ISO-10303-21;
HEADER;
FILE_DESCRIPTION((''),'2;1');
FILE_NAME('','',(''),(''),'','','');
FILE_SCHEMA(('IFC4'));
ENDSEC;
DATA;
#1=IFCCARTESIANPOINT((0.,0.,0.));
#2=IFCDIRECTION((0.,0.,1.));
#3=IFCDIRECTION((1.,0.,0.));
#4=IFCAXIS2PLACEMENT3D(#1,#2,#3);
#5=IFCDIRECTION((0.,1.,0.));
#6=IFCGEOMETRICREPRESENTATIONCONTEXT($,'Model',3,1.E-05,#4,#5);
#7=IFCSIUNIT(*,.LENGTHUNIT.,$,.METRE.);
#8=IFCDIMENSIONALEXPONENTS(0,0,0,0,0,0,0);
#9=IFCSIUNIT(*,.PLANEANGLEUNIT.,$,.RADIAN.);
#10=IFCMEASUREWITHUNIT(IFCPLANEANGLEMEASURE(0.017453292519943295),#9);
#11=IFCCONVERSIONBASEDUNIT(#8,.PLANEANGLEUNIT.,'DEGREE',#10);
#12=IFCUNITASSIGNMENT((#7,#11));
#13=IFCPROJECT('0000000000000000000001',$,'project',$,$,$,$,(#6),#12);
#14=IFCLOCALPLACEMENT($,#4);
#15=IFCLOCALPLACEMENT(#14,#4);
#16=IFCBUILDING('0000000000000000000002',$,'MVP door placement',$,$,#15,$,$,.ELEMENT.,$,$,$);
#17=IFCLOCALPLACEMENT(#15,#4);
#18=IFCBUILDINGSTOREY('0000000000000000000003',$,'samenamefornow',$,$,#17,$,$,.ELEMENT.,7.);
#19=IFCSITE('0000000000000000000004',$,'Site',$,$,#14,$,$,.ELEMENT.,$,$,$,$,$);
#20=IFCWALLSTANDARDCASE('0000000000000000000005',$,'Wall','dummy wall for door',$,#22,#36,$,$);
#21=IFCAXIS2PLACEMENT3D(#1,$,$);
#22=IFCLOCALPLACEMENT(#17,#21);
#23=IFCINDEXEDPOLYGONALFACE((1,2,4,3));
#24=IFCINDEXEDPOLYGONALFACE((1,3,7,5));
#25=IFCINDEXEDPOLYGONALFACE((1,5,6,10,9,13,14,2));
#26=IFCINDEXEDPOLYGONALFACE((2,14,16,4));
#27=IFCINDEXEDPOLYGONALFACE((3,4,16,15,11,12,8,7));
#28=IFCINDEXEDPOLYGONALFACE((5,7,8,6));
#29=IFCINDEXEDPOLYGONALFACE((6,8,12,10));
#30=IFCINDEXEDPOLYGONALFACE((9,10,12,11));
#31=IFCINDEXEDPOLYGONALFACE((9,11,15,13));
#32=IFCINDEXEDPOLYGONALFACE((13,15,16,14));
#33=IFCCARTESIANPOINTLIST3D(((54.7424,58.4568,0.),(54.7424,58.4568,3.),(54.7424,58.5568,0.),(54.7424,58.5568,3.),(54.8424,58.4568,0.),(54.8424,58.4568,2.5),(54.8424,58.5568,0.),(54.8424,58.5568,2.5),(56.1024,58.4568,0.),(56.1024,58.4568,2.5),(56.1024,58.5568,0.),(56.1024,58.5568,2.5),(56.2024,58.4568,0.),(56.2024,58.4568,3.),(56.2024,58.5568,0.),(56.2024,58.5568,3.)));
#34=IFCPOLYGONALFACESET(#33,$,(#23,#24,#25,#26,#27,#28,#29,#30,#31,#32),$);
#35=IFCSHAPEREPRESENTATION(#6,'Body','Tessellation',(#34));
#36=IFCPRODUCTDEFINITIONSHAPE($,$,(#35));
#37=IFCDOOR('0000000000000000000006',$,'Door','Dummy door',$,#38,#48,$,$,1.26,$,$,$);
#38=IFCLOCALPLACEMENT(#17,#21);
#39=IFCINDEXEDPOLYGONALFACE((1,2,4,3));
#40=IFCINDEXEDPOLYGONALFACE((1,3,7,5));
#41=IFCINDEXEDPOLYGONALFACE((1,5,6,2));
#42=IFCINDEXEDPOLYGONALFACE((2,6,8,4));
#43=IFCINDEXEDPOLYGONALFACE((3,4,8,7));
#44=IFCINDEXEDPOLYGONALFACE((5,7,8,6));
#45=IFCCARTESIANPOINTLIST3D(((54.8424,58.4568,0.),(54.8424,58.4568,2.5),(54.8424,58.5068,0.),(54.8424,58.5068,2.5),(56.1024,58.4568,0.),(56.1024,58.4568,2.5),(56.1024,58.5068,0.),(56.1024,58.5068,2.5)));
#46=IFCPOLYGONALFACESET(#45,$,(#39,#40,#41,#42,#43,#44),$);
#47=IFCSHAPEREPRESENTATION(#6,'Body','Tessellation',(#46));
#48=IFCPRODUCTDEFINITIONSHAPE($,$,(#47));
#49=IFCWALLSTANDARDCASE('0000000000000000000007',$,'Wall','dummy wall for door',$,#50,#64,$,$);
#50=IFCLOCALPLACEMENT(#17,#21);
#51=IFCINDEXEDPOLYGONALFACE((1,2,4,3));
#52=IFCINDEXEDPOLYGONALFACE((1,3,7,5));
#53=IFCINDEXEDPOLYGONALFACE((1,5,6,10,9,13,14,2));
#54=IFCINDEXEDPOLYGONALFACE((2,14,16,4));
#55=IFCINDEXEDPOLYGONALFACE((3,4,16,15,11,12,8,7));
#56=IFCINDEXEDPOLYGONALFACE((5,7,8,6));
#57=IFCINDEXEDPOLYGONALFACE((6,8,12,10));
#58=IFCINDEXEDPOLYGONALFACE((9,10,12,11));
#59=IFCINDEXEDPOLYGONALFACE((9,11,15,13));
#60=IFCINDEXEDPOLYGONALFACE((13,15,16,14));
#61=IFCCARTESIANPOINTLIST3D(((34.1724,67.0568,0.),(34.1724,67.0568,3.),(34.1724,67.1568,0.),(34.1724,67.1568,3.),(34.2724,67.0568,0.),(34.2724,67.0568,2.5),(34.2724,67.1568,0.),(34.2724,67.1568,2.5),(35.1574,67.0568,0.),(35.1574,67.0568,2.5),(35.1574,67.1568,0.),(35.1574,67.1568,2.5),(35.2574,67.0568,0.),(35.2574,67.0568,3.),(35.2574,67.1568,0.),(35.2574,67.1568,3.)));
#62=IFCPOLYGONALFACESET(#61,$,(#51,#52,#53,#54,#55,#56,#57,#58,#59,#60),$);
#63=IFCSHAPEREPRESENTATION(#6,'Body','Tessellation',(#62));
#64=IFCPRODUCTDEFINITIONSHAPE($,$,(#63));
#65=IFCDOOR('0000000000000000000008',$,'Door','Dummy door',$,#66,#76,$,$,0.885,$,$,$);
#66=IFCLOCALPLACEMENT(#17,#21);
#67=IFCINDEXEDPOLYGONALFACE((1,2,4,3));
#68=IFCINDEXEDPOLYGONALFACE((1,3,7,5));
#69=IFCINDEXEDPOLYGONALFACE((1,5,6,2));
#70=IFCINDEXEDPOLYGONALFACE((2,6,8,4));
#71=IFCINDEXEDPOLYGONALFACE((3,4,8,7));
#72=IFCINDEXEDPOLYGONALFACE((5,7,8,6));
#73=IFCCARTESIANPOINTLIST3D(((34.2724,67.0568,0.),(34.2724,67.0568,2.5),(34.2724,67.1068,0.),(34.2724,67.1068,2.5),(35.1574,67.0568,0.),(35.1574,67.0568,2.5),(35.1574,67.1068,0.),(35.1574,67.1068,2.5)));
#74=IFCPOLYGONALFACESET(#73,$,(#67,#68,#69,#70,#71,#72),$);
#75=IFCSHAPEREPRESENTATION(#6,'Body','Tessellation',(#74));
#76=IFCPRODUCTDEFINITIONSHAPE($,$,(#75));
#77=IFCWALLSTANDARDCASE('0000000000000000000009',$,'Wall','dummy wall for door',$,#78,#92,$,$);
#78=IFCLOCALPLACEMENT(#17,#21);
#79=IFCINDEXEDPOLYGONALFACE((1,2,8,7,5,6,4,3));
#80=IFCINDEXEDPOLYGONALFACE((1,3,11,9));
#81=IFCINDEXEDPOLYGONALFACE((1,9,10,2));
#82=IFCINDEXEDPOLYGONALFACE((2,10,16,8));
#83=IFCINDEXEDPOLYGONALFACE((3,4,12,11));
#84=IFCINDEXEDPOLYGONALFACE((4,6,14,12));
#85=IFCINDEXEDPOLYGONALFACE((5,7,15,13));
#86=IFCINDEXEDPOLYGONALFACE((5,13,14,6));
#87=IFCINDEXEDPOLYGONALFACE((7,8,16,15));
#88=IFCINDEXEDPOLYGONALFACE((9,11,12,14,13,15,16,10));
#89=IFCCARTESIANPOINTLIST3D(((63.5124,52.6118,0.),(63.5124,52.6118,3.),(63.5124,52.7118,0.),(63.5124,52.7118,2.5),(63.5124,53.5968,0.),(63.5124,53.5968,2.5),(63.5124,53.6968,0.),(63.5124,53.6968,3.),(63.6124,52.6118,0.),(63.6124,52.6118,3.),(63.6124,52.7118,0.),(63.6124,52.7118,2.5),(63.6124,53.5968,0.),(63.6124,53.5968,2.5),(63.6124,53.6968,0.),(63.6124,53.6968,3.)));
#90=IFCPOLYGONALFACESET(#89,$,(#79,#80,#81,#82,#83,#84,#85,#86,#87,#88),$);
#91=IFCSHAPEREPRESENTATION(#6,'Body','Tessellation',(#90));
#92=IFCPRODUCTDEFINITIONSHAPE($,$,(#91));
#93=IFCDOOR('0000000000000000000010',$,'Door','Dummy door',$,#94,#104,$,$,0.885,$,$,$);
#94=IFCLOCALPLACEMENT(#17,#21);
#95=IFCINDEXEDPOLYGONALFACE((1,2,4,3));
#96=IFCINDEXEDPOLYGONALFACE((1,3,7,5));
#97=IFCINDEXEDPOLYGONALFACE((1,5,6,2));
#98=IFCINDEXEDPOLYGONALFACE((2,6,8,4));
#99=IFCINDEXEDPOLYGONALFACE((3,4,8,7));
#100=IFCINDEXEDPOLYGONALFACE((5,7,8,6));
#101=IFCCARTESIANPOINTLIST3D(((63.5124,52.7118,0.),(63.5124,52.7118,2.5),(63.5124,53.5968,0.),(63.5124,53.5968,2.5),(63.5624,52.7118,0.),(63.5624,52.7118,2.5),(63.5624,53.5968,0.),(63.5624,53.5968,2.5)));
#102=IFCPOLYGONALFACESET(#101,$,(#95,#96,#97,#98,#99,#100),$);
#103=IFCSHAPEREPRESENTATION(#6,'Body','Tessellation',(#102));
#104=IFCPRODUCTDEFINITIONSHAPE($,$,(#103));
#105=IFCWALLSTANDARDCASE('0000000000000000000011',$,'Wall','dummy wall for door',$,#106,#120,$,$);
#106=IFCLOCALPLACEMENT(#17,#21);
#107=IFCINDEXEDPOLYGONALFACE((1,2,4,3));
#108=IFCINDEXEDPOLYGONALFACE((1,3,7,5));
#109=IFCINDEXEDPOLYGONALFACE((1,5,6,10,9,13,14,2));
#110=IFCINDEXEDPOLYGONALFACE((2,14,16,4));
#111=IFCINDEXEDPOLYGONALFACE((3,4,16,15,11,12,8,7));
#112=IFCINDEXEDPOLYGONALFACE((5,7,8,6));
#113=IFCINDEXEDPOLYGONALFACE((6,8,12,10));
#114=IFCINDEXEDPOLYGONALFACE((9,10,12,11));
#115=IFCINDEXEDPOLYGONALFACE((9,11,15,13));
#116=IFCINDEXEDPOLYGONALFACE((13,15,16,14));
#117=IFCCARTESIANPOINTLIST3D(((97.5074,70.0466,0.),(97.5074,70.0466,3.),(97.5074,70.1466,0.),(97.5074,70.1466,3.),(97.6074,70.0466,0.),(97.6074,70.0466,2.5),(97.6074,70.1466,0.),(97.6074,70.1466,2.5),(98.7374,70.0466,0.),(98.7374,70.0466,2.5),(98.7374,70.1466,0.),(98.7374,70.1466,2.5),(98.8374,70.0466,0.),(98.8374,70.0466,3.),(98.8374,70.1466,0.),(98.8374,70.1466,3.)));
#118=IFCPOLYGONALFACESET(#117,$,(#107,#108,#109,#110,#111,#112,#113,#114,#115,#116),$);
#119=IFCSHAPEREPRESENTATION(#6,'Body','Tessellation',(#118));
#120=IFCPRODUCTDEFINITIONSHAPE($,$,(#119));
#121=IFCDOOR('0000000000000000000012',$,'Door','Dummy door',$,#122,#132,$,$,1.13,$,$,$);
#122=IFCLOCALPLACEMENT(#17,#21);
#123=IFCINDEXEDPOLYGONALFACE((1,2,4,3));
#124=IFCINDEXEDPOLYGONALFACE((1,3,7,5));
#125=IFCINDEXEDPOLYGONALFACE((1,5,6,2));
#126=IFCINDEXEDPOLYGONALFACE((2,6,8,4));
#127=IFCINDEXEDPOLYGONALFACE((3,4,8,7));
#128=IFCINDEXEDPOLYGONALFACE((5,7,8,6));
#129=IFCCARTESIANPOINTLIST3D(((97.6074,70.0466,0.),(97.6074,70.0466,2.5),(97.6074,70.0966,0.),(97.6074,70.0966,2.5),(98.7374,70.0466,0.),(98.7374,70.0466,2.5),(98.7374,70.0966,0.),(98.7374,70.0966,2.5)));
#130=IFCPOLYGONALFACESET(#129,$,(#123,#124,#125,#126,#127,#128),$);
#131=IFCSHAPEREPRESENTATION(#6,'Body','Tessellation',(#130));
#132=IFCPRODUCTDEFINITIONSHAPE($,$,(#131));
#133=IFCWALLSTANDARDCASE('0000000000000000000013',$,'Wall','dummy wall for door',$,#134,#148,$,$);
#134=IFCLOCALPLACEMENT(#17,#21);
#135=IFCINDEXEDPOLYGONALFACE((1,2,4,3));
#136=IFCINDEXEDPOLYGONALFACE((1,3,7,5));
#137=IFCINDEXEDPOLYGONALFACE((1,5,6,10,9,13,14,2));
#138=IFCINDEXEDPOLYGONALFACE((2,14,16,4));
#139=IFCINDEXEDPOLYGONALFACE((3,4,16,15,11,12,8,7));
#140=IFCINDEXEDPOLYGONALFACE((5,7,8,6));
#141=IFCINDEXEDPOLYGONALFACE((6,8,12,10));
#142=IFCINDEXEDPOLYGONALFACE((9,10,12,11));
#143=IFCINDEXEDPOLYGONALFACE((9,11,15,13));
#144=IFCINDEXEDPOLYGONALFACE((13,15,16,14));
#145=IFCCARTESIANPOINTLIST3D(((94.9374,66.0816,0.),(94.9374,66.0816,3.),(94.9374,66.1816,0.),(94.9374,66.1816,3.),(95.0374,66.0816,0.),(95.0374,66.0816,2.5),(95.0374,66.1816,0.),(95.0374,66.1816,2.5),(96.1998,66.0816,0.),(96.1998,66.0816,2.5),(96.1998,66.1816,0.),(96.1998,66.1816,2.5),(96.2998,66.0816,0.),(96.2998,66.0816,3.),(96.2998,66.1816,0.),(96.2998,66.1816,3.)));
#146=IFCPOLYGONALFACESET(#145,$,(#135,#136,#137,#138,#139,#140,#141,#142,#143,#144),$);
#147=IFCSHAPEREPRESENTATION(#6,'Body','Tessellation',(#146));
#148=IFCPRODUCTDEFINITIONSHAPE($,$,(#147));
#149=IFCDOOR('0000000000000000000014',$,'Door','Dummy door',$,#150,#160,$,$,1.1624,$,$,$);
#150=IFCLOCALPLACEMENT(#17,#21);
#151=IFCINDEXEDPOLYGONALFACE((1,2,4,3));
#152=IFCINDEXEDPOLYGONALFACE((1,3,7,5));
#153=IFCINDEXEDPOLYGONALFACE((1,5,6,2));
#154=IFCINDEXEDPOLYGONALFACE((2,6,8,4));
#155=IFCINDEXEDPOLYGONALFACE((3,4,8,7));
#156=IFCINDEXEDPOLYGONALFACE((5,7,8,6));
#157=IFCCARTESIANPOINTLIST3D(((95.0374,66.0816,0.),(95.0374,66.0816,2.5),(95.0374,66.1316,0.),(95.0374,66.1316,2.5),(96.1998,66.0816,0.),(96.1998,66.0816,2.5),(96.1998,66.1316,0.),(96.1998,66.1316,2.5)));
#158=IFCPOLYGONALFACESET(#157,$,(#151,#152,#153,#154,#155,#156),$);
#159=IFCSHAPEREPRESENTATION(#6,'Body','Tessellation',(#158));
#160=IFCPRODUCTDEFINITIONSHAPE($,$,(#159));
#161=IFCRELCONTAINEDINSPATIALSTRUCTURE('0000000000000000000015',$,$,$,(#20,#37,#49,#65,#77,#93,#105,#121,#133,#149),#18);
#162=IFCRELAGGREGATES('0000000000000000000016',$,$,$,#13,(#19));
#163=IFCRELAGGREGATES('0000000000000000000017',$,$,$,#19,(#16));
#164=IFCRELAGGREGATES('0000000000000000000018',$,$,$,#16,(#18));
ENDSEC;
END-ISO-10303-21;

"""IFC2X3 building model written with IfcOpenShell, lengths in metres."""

from ifc_helpers import new_model, entity, si_unit, converted_unit, direction, origin_with_axes, place, context, project, spatial, polyline, outline, extrude, element, fill, save


model = new_model("IFC2X3")

# Units and contexts
model_context = context("Model", 3, precision=1e-05, world=origin_with_axes(), true_north=direction((0.0, 1.0, 0.0)))
ifc_project = project(units=[si_unit("LENGTHUNIT", "METRE"), converted_unit("PLANEANGLEUNIT", "DEGREE", entity("IfcPlaneAngleMeasure", 0.017453292519943295), si_unit("PLANEANGLEUNIT", "RADIAN"), dimensions=[0, 0, 0, 0, 0, 0, 0])], contexts=[model_context])

# Site, building, storey
site_placement = place(None, origin_with_axes())
site = spatial("IfcSite", under=ifc_project, at=site_placement, Name="Site", CompositionType="ELEMENT")
building_placement = place(site_placement, origin_with_axes())
building = spatial("IfcBuilding", under=site, at=building_placement, Name="MVP door placement", CompositionType="ELEMENT")
storey_placement = place(building_placement, origin_with_axes())
storey = spatial("IfcBuildingStorey", under=building, at=storey_placement, Name="samenamefornow", CompositionType="ELEMENT", Elevation=7.0)

# Walls, openings, doors
wall_1_placement = place(storey_placement, origin_with_axes())
wall_1 = element("IfcWallStandardCase", 1, at=wall_1_placement, inside=storey, Name="Wall", Description="dummy wall for door", context=model_context, shape_type="SweptSolid", body=[
    extrude(outline(polyline([(56.2024, 58.4568, 0.0), (54.7424, 58.4568, 0.0), (54.7424, 58.5568, 0.0), (56.2024, 58.5568, 0.0), (56.2024, 58.4568, 0.0)])), origin_with_axes(), (0.0, 0.0, 1.0), 3.0),
])
opening_1_placement = place(wall_1_placement, origin_with_axes())
opening_1 = element("IfcOpeningElement", 2, at=opening_1_placement, cuts=wall_1, context=model_context, shape_type="SweptSolid", body=[
    extrude(outline(polyline([(56.1024, 58.4568, 0.0), (54.8424, 58.4568, 0.0), (54.8424, 58.5568, 0.0), (56.1024, 58.5568, 0.0), (56.1024, 58.4568, 0.0)])), origin_with_axes(), (0.0, 0.0, 1.0), 2.5),
])
door_1_placement = place(opening_1_placement, origin_with_axes())
door_1 = element("IfcDoor", 3, at=door_1_placement, inside=storey, Name="Door", Description="Dummy door", OverallWidth=1.26, context=model_context, shape_type="SweptSolid", body=[
    extrude(outline(polyline([(56.1024, 58.4568, 0.0), (54.8424, 58.4568, 0.0), (54.8424, 58.5068, 0.0), (56.1024, 58.5068, 0.0), (56.1024, 58.4568, 0.0)])), origin_with_axes(), (0.0, 0.0, 1.0), 2.5),
])
fill(opening_1, door_1)
wall_2_placement = place(storey_placement, origin_with_axes())
wall_2 = element("IfcWallStandardCase", 4, at=wall_2_placement, inside=storey, Name="Wall", Description="dummy wall for door", context=model_context, shape_type="SweptSolid", body=[
    extrude(outline(polyline([(35.2574, 67.0568, 0.0), (34.1724, 67.0568, 0.0), (34.1724, 67.1568, 0.0), (35.2574, 67.1568, 0.0), (35.2574, 67.0568, 0.0)])), origin_with_axes(), (0.0, 0.0, 1.0), 3.0),
])
opening_2_placement = place(wall_2_placement, origin_with_axes())
opening_2 = element("IfcOpeningElement", 5, at=opening_2_placement, cuts=wall_2, context=model_context, shape_type="SweptSolid", body=[
    extrude(outline(polyline([(35.1574, 67.0568, 0.0), (34.2724, 67.0568, 0.0), (34.2724, 67.1568, 0.0), (35.1574, 67.1568, 0.0), (35.1574, 67.0568, 0.0)])), origin_with_axes(), (0.0, 0.0, 1.0), 2.5),
])
door_2_placement = place(opening_2_placement, origin_with_axes())
door_2 = element("IfcDoor", 6, at=door_2_placement, inside=storey, Name="Door", Description="Dummy door", OverallWidth=0.885, context=model_context, shape_type="SweptSolid", body=[
    extrude(outline(polyline([(35.1574, 67.0568, 0.0), (34.2724, 67.0568, 0.0), (34.2724, 67.1068, 0.0), (35.1574, 67.1068, 0.0), (35.1574, 67.0568, 0.0)])), origin_with_axes(), (0.0, 0.0, 1.0), 2.5),
])
fill(opening_2, door_2)
wall_3_placement = place(storey_placement, origin_with_axes())
wall_3 = element("IfcWallStandardCase", 7, at=wall_3_placement, inside=storey, Name="Wall", Description="dummy wall for door", context=model_context, shape_type="SweptSolid", body=[
    extrude(outline(polyline([(63.5124, 52.6118, 0.0), (63.5124, 53.6968, 0.0), (63.6124, 53.6968, 0.0), (63.6124, 52.6118, 0.0), (63.5124, 52.6118, 0.0)])), origin_with_axes(), (0.0, 0.0, 1.0), 3.0),
])
opening_3_placement = place(wall_3_placement, origin_with_axes())
opening_3 = element("IfcOpeningElement", 8, at=opening_3_placement, cuts=wall_3, context=model_context, shape_type="SweptSolid", body=[
    extrude(outline(polyline([(63.5124, 52.7118, 0.0), (63.5124, 53.5968, 0.0), (63.6124, 53.5968, 0.0), (63.6124, 52.7118, 0.0), (63.5124, 52.7118, 0.0)])), origin_with_axes(), (0.0, 0.0, 1.0), 2.5),
])
door_3_placement = place(opening_3_placement, origin_with_axes())
door_3 = element("IfcDoor", 9, at=door_3_placement, inside=storey, Name="Door", Description="Dummy door", OverallWidth=0.885, context=model_context, shape_type="SweptSolid", body=[
    extrude(outline(polyline([(63.5124, 52.7118, 0.0), (63.5124, 53.5968, 0.0), (63.5624, 53.5968, 0.0), (63.5624, 52.7118, 0.0), (63.5124, 52.7118, 0.0)])), origin_with_axes(), (0.0, 0.0, 1.0), 2.5),
])
fill(opening_3, door_3)
wall_4_placement = place(storey_placement, origin_with_axes())
wall_4 = element("IfcWallStandardCase", 10, at=wall_4_placement, inside=storey, Name="Wall", Description="dummy wall for door", context=model_context, shape_type="SweptSolid", body=[
    extrude(outline(polyline([(98.8374, 70.0466, 0.0), (97.5074, 70.0466, 0.0), (97.5074, 70.1466, 0.0), (98.8374, 70.1466, 0.0), (98.8374, 70.0466, 0.0)])), origin_with_axes(), (0.0, 0.0, 1.0), 3.0),
])
opening_4_placement = place(wall_4_placement, origin_with_axes())
opening_4 = element("IfcOpeningElement", 11, at=opening_4_placement, cuts=wall_4, context=model_context, shape_type="SweptSolid", body=[
    extrude(outline(polyline([(98.7374, 70.0466, 0.0), (97.6074, 70.0466, 0.0), (97.6074, 70.1466, 0.0), (98.7374, 70.1466, 0.0), (98.7374, 70.0466, 0.0)])), origin_with_axes(), (0.0, 0.0, 1.0), 2.5),
])
door_4_placement = place(opening_4_placement, origin_with_axes())
door_4 = element("IfcDoor", 12, at=door_4_placement, inside=storey, Name="Door", Description="Dummy door", OverallWidth=1.13, context=model_context, shape_type="SweptSolid", body=[
    extrude(outline(polyline([(98.7374, 70.0466, 0.0), (97.6074, 70.0466, 0.0), (97.6074, 70.0966, 0.0), (98.7374, 70.0966, 0.0), (98.7374, 70.0466, 0.0)])), origin_with_axes(), (0.0, 0.0, 1.0), 2.5),
])
fill(opening_4, door_4)
wall_5_placement = place(storey_placement, origin_with_axes())
wall_5 = element("IfcWallStandardCase", 13, at=wall_5_placement, inside=storey, Name="Wall", Description="dummy wall for door", context=model_context, shape_type="SweptSolid", body=[
    extrude(outline(polyline([(94.9374, 66.0816, 0.0), (96.2998, 66.0816, 0.0), (96.2998, 66.1816, 0.0), (94.9374, 66.1816, 0.0), (94.9374, 66.0816, 0.0)])), origin_with_axes(), (0.0, 0.0, 1.0), 3.0),
])
opening_5_placement = place(wall_5_placement, origin_with_axes())
opening_5 = element("IfcOpeningElement", 14, at=opening_5_placement, cuts=wall_5, context=model_context, shape_type="SweptSolid", body=[
    extrude(outline(polyline([(95.0374, 66.0816, 0.0), (96.1998, 66.0816, 0.0), (96.1998, 66.1816, 0.0), (95.0374, 66.1816, 0.0), (95.0374, 66.0816, 0.0)])), origin_with_axes(), (0.0, 0.0, 1.0), 2.5),
])
door_5_placement = place(opening_5_placement, origin_with_axes())
door_5 = element("IfcDoor", 15, at=door_5_placement, inside=storey, Name="Door", Description="Dummy door", OverallWidth=1.1624, context=model_context, shape_type="SweptSolid", body=[
    extrude(outline(polyline([(95.0374, 66.0816, 0.0), (96.1998, 66.0816, 0.0), (96.1998, 66.1316, 0.0), (95.0374, 66.1316, 0.0), (95.0374, 66.0816, 0.0)])), origin_with_axes(), (0.0, 0.0, 1.0), 2.5),
])
fill(opening_5, door_5)

save(model, "model.ifc")
